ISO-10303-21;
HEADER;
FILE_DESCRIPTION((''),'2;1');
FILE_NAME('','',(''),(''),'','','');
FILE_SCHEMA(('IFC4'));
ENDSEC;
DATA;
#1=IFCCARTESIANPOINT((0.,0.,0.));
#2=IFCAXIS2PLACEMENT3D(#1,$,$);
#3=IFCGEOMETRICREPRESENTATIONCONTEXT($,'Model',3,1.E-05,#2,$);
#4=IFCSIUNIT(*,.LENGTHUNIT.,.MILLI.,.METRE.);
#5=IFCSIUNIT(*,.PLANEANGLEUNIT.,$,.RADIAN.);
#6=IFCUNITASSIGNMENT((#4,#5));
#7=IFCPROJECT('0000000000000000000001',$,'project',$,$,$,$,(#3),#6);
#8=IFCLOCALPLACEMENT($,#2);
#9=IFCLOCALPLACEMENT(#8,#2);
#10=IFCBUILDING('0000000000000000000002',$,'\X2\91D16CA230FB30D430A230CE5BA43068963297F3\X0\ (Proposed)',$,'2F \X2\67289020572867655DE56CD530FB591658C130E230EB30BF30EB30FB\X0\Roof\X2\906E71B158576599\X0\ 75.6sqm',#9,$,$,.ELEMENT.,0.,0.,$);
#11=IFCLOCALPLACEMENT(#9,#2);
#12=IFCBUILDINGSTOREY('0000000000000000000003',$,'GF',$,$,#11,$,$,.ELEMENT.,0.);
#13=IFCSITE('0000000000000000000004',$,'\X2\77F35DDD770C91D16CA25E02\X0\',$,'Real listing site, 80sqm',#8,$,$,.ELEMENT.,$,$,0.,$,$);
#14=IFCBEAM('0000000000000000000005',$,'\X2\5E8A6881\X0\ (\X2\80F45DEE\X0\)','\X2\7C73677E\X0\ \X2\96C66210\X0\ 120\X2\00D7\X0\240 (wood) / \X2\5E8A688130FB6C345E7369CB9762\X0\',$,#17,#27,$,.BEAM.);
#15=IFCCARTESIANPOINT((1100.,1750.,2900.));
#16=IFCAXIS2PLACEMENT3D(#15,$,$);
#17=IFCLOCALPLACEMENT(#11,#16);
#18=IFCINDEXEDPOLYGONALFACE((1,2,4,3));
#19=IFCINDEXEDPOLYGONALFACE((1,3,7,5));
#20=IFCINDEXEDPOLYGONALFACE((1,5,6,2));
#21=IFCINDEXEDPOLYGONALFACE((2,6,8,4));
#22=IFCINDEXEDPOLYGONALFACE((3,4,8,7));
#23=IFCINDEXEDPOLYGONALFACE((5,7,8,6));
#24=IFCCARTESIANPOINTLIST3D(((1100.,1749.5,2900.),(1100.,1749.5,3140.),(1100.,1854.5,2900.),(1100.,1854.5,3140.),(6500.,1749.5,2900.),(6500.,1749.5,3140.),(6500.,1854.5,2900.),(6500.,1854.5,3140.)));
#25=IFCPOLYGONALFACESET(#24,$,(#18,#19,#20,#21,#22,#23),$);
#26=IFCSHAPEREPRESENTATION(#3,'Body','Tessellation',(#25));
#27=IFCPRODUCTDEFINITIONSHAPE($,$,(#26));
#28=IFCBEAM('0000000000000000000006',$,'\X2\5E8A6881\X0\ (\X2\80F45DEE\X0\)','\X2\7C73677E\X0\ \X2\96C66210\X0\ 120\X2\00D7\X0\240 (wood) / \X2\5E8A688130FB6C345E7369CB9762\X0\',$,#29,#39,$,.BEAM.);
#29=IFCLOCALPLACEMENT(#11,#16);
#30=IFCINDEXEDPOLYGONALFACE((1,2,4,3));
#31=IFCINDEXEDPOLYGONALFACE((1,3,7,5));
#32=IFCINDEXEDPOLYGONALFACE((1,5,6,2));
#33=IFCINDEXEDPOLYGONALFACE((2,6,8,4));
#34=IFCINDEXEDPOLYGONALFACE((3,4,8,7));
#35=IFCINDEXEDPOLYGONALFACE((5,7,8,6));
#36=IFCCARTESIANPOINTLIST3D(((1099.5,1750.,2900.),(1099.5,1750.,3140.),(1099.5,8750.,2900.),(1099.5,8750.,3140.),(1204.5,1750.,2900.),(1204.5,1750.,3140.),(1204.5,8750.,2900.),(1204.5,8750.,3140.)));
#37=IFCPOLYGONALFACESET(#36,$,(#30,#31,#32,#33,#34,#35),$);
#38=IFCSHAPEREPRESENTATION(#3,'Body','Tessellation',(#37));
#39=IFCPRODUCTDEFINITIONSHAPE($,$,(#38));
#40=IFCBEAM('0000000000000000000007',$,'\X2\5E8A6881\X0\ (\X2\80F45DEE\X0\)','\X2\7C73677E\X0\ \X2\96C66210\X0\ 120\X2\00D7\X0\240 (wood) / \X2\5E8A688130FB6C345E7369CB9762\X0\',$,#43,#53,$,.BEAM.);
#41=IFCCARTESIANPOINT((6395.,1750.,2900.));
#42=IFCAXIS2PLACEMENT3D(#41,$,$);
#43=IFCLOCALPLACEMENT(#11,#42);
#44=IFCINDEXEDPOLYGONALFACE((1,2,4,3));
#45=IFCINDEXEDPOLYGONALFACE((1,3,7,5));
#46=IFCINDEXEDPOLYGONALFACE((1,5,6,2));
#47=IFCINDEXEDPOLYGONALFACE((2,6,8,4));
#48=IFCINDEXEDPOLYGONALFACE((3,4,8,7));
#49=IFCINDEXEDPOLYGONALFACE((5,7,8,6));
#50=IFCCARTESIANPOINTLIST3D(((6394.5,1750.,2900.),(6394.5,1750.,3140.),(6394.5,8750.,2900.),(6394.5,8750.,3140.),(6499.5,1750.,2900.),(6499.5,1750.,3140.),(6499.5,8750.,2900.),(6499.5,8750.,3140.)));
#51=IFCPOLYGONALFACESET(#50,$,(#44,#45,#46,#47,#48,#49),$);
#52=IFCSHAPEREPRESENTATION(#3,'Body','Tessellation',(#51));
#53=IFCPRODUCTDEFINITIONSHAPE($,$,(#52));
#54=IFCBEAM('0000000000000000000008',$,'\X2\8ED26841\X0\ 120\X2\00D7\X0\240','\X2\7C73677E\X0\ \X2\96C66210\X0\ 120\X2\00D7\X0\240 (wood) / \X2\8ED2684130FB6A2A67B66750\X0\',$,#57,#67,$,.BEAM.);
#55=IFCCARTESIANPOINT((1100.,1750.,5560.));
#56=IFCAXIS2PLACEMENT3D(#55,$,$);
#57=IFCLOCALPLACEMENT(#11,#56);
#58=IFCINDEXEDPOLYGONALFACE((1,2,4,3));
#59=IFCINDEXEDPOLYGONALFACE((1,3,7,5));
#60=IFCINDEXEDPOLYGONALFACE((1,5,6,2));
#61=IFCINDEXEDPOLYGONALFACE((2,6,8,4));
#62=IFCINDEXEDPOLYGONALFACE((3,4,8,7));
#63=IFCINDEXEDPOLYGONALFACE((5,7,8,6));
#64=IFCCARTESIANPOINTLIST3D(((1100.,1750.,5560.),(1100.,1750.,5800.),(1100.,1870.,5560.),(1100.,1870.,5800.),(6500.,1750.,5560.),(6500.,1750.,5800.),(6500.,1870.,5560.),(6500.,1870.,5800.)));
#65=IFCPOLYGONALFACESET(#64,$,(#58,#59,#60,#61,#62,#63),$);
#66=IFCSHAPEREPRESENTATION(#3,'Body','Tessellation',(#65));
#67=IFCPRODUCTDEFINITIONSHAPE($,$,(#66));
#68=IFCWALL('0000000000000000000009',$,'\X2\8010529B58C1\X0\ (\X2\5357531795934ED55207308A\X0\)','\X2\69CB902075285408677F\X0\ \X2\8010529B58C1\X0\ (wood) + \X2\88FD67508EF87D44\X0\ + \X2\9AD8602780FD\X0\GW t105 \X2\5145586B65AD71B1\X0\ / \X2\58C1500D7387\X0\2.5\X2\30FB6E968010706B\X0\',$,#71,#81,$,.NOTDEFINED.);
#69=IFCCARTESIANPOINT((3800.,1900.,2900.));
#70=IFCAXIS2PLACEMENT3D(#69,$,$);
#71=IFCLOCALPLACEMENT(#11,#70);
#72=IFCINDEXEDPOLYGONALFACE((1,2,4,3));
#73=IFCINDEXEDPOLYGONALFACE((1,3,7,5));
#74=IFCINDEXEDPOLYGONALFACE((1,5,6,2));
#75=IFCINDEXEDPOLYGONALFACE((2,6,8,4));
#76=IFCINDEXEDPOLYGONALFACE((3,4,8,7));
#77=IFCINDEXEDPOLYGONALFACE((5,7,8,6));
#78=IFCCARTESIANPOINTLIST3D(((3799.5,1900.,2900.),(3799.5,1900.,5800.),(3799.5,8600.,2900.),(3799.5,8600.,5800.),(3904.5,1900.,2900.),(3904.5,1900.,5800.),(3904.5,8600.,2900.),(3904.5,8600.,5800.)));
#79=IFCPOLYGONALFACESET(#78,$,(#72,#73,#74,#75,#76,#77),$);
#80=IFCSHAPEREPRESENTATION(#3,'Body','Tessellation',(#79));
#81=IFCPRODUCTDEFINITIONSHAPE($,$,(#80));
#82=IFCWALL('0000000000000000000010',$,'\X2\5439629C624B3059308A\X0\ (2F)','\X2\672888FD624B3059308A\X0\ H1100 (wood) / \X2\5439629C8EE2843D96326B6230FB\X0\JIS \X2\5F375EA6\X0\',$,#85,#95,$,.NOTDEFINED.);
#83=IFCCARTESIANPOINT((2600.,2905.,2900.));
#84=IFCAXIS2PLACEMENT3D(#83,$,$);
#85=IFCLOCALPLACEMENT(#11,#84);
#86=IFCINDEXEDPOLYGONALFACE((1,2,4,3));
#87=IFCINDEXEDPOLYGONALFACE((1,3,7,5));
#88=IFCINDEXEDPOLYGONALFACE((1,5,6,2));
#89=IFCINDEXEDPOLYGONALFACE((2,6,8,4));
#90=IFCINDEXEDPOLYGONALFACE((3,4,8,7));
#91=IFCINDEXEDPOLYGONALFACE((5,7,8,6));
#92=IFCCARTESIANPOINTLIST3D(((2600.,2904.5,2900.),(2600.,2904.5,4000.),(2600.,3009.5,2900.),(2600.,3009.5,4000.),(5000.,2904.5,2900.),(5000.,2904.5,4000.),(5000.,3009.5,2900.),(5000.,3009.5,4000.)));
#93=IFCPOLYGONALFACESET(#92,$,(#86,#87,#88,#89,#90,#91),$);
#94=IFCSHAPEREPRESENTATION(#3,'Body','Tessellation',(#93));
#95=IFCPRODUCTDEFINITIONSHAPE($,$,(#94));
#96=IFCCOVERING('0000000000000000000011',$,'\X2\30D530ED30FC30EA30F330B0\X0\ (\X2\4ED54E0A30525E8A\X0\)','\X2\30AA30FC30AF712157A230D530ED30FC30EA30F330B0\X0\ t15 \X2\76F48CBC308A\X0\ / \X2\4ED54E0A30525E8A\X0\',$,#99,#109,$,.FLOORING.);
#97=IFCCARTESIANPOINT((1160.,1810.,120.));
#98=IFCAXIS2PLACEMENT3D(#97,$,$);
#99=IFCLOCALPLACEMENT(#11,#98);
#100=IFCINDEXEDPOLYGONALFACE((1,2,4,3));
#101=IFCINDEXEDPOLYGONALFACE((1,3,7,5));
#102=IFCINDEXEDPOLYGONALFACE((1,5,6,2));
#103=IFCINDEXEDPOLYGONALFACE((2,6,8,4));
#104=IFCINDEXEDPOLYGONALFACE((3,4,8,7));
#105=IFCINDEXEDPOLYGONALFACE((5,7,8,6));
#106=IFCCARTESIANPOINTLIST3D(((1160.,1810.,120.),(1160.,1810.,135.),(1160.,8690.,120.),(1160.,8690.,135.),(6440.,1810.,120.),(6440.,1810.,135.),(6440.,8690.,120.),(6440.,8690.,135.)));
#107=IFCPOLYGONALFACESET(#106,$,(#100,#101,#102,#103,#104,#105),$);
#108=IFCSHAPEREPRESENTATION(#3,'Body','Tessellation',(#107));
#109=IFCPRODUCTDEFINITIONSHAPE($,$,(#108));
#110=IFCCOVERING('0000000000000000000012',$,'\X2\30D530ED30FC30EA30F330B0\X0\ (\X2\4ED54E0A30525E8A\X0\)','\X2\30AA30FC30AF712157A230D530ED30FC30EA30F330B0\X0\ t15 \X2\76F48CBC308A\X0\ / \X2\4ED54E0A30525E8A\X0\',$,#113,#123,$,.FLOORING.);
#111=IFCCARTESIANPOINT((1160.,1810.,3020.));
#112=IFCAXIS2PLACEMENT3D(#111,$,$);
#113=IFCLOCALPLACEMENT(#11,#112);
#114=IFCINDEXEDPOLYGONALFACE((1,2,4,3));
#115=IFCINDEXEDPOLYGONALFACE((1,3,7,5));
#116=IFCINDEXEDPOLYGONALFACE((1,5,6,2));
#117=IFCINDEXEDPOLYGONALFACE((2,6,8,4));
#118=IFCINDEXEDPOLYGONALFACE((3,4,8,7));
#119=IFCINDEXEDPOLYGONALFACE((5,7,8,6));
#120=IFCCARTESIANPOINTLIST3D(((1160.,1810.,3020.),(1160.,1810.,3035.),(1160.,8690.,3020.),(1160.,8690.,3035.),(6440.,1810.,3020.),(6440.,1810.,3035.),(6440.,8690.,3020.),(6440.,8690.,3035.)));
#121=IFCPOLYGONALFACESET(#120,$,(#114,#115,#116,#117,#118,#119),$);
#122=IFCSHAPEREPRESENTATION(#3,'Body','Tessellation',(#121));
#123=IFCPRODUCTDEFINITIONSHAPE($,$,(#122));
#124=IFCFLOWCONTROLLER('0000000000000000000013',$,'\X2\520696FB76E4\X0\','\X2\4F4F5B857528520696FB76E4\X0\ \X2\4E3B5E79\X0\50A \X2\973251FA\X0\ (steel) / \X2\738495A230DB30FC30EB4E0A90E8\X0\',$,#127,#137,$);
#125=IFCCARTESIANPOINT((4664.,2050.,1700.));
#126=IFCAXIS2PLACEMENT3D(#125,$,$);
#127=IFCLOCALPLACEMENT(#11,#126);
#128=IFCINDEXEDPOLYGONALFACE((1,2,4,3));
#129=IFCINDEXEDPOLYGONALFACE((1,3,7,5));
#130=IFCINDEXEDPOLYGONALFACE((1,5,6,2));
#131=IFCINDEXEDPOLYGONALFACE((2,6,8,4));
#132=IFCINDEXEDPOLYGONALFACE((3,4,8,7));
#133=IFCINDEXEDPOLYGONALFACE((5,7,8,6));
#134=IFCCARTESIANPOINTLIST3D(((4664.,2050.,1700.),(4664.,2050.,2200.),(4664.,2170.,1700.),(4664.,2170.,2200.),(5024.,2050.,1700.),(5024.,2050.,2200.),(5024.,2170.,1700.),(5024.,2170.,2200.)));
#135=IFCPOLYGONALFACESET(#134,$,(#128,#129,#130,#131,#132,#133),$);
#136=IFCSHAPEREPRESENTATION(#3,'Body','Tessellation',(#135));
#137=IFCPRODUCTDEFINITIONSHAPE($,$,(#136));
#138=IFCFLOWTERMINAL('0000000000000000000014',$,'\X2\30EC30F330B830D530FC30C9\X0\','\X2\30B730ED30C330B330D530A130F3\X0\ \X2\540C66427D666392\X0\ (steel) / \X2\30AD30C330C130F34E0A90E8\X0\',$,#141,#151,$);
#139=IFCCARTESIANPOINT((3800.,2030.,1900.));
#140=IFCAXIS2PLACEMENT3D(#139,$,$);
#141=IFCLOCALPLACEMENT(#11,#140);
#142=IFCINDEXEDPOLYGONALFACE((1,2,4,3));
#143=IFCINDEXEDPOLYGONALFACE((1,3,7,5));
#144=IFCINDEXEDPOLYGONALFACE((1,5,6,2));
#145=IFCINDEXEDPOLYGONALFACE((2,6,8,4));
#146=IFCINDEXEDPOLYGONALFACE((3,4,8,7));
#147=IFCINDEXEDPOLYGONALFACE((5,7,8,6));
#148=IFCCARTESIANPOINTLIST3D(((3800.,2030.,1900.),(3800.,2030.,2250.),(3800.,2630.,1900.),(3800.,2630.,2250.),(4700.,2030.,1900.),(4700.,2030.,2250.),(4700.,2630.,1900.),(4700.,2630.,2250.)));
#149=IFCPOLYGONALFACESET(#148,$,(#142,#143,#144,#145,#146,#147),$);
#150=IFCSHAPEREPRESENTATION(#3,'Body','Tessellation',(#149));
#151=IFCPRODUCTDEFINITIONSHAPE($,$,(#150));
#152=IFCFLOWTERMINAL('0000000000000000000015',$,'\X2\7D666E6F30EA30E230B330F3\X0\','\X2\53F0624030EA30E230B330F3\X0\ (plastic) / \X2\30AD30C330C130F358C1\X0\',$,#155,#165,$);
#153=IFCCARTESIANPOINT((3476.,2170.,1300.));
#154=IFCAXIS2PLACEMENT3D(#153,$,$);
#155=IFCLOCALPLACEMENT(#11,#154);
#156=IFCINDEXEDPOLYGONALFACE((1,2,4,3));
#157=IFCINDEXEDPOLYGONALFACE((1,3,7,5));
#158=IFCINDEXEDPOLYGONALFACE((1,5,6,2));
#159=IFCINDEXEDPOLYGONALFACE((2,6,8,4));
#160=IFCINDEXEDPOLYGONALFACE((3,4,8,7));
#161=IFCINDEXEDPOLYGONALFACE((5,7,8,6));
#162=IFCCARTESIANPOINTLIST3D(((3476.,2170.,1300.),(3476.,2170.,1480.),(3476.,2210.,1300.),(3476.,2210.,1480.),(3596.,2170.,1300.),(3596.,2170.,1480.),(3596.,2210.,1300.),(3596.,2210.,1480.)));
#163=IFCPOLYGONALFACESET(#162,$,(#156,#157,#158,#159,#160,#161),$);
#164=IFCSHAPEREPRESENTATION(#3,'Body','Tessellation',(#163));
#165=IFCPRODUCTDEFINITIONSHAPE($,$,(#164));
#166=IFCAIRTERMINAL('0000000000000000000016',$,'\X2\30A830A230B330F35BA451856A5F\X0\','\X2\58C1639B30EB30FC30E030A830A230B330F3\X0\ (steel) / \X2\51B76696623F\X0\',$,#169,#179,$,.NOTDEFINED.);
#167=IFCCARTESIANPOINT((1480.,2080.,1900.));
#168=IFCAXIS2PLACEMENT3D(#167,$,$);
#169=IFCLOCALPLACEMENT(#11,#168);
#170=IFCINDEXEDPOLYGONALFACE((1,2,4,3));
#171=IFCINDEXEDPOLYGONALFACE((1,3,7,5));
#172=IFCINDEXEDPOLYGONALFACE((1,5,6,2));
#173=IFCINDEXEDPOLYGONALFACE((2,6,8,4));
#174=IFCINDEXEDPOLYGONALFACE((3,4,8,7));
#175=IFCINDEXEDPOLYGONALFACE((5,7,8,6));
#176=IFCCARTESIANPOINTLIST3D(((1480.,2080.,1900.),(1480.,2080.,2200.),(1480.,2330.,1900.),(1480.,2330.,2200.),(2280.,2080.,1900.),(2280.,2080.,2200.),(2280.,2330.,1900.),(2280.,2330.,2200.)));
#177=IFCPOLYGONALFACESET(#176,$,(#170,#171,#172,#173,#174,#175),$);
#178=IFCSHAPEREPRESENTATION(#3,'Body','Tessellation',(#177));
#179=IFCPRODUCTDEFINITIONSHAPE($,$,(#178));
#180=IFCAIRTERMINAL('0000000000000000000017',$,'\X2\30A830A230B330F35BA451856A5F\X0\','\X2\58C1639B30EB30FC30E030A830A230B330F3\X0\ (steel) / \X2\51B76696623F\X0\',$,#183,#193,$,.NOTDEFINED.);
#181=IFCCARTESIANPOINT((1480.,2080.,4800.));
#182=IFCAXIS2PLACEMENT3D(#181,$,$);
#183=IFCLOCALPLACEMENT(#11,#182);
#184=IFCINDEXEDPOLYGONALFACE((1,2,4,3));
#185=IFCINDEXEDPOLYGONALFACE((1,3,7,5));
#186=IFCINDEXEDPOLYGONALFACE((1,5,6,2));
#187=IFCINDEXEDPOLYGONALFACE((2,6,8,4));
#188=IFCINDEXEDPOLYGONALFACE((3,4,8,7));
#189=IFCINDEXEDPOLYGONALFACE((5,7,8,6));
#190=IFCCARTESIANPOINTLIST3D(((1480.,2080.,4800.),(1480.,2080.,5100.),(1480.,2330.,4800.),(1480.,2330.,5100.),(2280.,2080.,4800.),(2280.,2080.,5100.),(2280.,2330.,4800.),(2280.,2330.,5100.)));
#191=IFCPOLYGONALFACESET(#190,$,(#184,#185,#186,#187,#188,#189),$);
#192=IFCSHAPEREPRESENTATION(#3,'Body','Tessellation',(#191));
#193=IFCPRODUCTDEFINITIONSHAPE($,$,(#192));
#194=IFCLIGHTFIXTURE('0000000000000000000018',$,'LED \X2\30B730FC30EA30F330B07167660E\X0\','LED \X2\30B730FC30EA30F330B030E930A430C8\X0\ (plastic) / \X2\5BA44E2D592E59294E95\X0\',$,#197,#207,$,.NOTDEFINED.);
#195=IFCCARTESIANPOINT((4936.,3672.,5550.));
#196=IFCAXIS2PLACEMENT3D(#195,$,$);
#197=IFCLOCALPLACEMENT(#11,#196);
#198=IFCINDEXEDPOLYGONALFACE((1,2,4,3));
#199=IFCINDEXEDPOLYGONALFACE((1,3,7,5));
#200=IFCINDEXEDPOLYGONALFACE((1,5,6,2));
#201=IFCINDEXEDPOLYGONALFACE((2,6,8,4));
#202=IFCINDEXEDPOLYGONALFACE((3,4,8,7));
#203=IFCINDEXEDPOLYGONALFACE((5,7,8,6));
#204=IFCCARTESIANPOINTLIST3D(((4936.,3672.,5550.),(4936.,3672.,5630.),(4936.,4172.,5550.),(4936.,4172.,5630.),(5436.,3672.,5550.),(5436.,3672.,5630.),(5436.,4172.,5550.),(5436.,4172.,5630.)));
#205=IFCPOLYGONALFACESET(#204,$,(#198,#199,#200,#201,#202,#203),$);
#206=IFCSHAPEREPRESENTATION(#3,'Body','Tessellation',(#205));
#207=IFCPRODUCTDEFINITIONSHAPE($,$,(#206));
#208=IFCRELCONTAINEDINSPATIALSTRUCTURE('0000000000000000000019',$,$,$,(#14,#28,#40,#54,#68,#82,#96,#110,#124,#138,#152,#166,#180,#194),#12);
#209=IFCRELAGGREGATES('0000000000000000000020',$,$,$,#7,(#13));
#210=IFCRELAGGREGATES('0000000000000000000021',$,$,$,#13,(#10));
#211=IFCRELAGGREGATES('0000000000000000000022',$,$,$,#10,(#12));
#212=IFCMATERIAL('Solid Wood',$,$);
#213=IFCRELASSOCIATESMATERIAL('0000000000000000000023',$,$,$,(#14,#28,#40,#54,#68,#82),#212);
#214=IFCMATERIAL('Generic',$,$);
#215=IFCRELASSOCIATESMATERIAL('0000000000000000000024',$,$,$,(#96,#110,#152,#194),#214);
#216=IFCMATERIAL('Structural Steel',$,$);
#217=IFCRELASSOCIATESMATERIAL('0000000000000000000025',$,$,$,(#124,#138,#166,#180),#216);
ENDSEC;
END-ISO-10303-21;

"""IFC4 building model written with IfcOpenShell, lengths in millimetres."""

from ifc_helpers import new_model, si_unit, frame, frame_2d, origin, place, context, project, spatial, rectangle, extrude, material, element, save


model = new_model("IFC4")

# Units and contexts
model_context = context("Model", 3, precision=1e-05, world=origin())
ifc_project = project(units=[si_unit("LENGTHUNIT", "METRE", prefix="MILLI"), si_unit("PLANEANGLEUNIT", "RADIAN")], contexts=[model_context])

# Site, building, storey
site_placement = place(None, origin())
site = spatial("IfcSite", under=ifc_project, at=site_placement, Name="石川県金沢市", ObjectType="Real listing site, 80sqm", CompositionType="ELEMENT", RefElevation=0.0)
building_placement = place(site_placement, origin())
building = spatial("IfcBuilding", under=site, at=building_placement, Name="金沢・ピアノ室と防音 (Proposed)", ObjectType="2F 木造在来工法・外壁モルタル・Roof遮熱塗料 75.6sqm", CompositionType="ELEMENT", ElevationOfRefHeight=0.0, ElevationOfTerrain=0.0)
storey_placement = place(building_placement, origin())
storey = spatial("IfcBuildingStorey", under=building, at=storey_placement, Name="GF", CompositionType="ELEMENT", Elevation=0.0)

# Shared definitions
ifc_material_1 = material(Name="Solid Wood")

# Beams
beam_1_placement = place(storey_placement, frame((1100.0, 1750.0, 2900.0)))
element("IfcBeam", 1, at=beam_1_placement, inside=storey, material=ifc_material_1, Name="床梁 (胴差)", Description="米松 集成 120×240 (wood) / 床梁・水平構面", PredefinedType="BEAM", context=model_context, shape_type="SweptSolid", body=[
    extrude(rectangle(XDim=5400.0, YDim=105.0, at=frame_2d((2700.0, 52.0))), frame((1100.0, 1750.0, 2900.0)), (0.0, 0.0, 1.0), 240.0),
])
beam_2_placement = place(storey_placement, frame((1100.0, 1750.0, 2900.0)))
element("IfcBeam", 2, at=beam_2_placement, inside=storey, material=ifc_material_1, Name="床梁 (胴差)", Description="米松 集成 120×240 (wood) / 床梁・水平構面", PredefinedType="BEAM", context=model_context, shape_type="SweptSolid", body=[
    extrude(rectangle(XDim=105.0, YDim=7000.0, at=frame_2d((52.0, 3500.0))), frame((1100.0, 1750.0, 2900.0)), (0.0, 0.0, 1.0), 240.0),
])
beam_3_placement = place(storey_placement, frame((6395.0, 1750.0, 2900.0)))
element("IfcBeam", 3, at=beam_3_placement, inside=storey, material=ifc_material_1, Name="床梁 (胴差)", Description="米松 集成 120×240 (wood) / 床梁・水平構面", PredefinedType="BEAM", context=model_context, shape_type="SweptSolid", body=[
    extrude(rectangle(XDim=105.0, YDim=7000.0, at=frame_2d((52.0, 3500.0))), frame((6395.0, 1750.0, 2900.0)), (0.0, 0.0, 1.0), 240.0),
])
beam_4_placement = place(storey_placement, frame((1100.0, 1750.0, 5560.0)))
element("IfcBeam", 4, at=beam_4_placement, inside=storey, material=ifc_material_1, Name="軒桁 120×240", Description="米松 集成 120×240 (wood) / 軒桁・横架材", PredefinedType="BEAM", context=model_context, shape_type="SweptSolid", body=[
    extrude(rectangle(XDim=5400.0, YDim=120.0, at=frame_2d((2700.0, 60.0))), frame((1100.0, 1750.0, 5560.0)), (0.0, 0.0, 1.0), 240.0),
])

# Walls
wall_1_placement = place(storey_placement, frame((3800.0, 1900.0, 2900.0)))
element("IfcWall", 5, at=wall_1_placement, inside=storey, material=ifc_material_1, Name="耐力壁 (南北間仕切り)", Description="構造用合板 耐力壁 (wood) + 製材軸組 + 高性能GW t105 充填断熱 / 壁倍率2.5・準耐火", PredefinedType="NOTDEFINED", context=model_context, shape_type="SweptSolid", body=[
    extrude(rectangle(XDim=105.0, YDim=6700.0, at=frame_2d((52.0, 3350.0))), frame((3800.0, 1900.0, 2900.0)), (0.0, 0.0, 1.0), 2900.0),
])
wall_2_placement = place(storey_placement, frame((2600.0, 2905.0, 2900.0)))
element("IfcWall", 6, at=wall_2_placement, inside=storey, material=ifc_material_1, Name="吹抜手すり (2F)", Description="木製手すり H1100 (wood) / 吹抜転落防止・JIS 強度", PredefinedType="NOTDEFINED", context=model_context, shape_type="SweptSolid", body=[
    extrude(rectangle(XDim=2400.0, YDim=105.0, at=frame_2d((1200.0, 52.0))), frame((2600.0, 2905.0, 2900.0)), (0.0, 0.0, 1.0), 1100.0),
])

# Coverings
ifc_material_2 = material(Name="Generic")
covering_1_placement = place(storey_placement, frame((1160.0, 1810.0, 120.0)))
element("IfcCovering", 7, at=covering_1_placement, inside=storey, material=ifc_material_2, Name="フローリング (仕上げ床)", Description="オーク無垢フローリング t15 直貼り / 仕上げ床", PredefinedType="FLOORING", context=model_context, shape_type="SweptSolid", body=[
    extrude(rectangle(XDim=5280.0, YDim=6880.0, at=frame_2d((2640.0, 3440.0))), frame((1160.0, 1810.0, 120.0)), (0.0, 0.0, 1.0), 15.0),
])
covering_2_placement = place(storey_placement, frame((1160.0, 1810.0, 3020.0)))
element("IfcCovering", 8, at=covering_2_placement, inside=storey, material=ifc_material_2, Name="フローリング (仕上げ床)", Description="オーク無垢フローリング t15 直貼り / 仕上げ床", PredefinedType="FLOORING", context=model_context, shape_type="SweptSolid", body=[
    extrude(rectangle(XDim=5280.0, YDim=6880.0, at=frame_2d((2640.0, 3440.0))), frame((1160.0, 1810.0, 3020.0)), (0.0, 0.0, 1.0), 15.0),
])

# Flow controller
ifc_material_3 = material(Name="Structural Steel")
flow_controller_placement = place(storey_placement, frame((4664.0, 2050.0, 1700.0)))
element("IfcFlowController", 9, at=flow_controller_placement, inside=storey, material=ifc_material_3, Name="分電盤", Description="住宅用分電盤 主幹50A 露出 (steel) / 玄関ホール上部", context=model_context, shape_type="SweptSolid", body=[
    extrude(rectangle(XDim=360.0, YDim=120.0, at=frame_2d((180.0, 60.0))), frame((4664.0, 2050.0, 1700.0)), (0.0, 0.0, 1.0), 500.0),
])

# Flow terminals
flow_terminal_1_placement = place(storey_placement, frame((3800.0, 2030.0, 1900.0)))
element("IfcFlowTerminal", 10, at=flow_terminal_1_placement, inside=storey, material=ifc_material_3, Name="レンジフード", Description="シロッコファン 同時給排 (steel) / キッチン上部", context=model_context, shape_type="SweptSolid", body=[
    extrude(rectangle(XDim=900.0, YDim=600.0, at=frame_2d((450.0, 300.0))), frame((3800.0, 2030.0, 1900.0)), (0.0, 0.0, 1.0), 350.0),
])
flow_terminal_2_placement = place(storey_placement, frame((3476.0, 2170.0, 1300.0)))
element("IfcFlowTerminal", 11, at=flow_terminal_2_placement, inside=storey, material=ifc_material_2, Name="給湯リモコン", Description="台所リモコン (plastic) / キッチン壁", context=model_context, shape_type="SweptSolid", body=[
    extrude(rectangle(XDim=120.0, YDim=40.0, at=frame_2d((60.0, 20.0))), frame((3476.0, 2170.0, 1300.0)), (0.0, 0.0, 1.0), 180.0),
])

# Air terminals
air_terminal_1_placement = place(storey_placement, frame((1480.0, 2080.0, 1900.0)))
element("IfcAirTerminal", 12, at=air_terminal_1_placement, inside=storey, material=ifc_material_3, Name="エアコン室内機", Description="壁掛ルームエアコン (steel) / 冷暖房", PredefinedType="NOTDEFINED", context=model_context, shape_type="SweptSolid", body=[
    extrude(rectangle(XDim=800.0, YDim=250.0, at=frame_2d((400.0, 125.0))), frame((1480.0, 2080.0, 1900.0)), (0.0, 0.0, 1.0), 300.0),
])
air_terminal_2_placement = place(storey_placement, frame((1480.0, 2080.0, 4800.0)))
element("IfcAirTerminal", 13, at=air_terminal_2_placement, inside=storey, material=ifc_material_3, Name="エアコン室内機", Description="壁掛ルームエアコン (steel) / 冷暖房", PredefinedType="NOTDEFINED", context=model_context, shape_type="SweptSolid", body=[
    extrude(rectangle(XDim=800.0, YDim=250.0, at=frame_2d((400.0, 125.0))), frame((1480.0, 2080.0, 4800.0)), (0.0, 0.0, 1.0), 300.0),
])

# Light fixture
light_fixture_placement = place(storey_placement, frame((4936.0, 3672.0, 5550.0)))
element("IfcLightFixture", 14, at=light_fixture_placement, inside=storey, material=ifc_material_2, Name="LED シーリング照明", Description="LED シーリングライト (plastic) / 室中央天井", PredefinedType="NOTDEFINED", context=model_context, shape_type="SweptSolid", body=[
    extrude(rectangle(XDim=500.0, YDim=500.0, at=frame_2d((250.0, 250.0))), frame((4936.0, 3672.0, 5550.0)), (0.0, 0.0, 1.0), 80.0),
])

save(model, "model.ifc")
